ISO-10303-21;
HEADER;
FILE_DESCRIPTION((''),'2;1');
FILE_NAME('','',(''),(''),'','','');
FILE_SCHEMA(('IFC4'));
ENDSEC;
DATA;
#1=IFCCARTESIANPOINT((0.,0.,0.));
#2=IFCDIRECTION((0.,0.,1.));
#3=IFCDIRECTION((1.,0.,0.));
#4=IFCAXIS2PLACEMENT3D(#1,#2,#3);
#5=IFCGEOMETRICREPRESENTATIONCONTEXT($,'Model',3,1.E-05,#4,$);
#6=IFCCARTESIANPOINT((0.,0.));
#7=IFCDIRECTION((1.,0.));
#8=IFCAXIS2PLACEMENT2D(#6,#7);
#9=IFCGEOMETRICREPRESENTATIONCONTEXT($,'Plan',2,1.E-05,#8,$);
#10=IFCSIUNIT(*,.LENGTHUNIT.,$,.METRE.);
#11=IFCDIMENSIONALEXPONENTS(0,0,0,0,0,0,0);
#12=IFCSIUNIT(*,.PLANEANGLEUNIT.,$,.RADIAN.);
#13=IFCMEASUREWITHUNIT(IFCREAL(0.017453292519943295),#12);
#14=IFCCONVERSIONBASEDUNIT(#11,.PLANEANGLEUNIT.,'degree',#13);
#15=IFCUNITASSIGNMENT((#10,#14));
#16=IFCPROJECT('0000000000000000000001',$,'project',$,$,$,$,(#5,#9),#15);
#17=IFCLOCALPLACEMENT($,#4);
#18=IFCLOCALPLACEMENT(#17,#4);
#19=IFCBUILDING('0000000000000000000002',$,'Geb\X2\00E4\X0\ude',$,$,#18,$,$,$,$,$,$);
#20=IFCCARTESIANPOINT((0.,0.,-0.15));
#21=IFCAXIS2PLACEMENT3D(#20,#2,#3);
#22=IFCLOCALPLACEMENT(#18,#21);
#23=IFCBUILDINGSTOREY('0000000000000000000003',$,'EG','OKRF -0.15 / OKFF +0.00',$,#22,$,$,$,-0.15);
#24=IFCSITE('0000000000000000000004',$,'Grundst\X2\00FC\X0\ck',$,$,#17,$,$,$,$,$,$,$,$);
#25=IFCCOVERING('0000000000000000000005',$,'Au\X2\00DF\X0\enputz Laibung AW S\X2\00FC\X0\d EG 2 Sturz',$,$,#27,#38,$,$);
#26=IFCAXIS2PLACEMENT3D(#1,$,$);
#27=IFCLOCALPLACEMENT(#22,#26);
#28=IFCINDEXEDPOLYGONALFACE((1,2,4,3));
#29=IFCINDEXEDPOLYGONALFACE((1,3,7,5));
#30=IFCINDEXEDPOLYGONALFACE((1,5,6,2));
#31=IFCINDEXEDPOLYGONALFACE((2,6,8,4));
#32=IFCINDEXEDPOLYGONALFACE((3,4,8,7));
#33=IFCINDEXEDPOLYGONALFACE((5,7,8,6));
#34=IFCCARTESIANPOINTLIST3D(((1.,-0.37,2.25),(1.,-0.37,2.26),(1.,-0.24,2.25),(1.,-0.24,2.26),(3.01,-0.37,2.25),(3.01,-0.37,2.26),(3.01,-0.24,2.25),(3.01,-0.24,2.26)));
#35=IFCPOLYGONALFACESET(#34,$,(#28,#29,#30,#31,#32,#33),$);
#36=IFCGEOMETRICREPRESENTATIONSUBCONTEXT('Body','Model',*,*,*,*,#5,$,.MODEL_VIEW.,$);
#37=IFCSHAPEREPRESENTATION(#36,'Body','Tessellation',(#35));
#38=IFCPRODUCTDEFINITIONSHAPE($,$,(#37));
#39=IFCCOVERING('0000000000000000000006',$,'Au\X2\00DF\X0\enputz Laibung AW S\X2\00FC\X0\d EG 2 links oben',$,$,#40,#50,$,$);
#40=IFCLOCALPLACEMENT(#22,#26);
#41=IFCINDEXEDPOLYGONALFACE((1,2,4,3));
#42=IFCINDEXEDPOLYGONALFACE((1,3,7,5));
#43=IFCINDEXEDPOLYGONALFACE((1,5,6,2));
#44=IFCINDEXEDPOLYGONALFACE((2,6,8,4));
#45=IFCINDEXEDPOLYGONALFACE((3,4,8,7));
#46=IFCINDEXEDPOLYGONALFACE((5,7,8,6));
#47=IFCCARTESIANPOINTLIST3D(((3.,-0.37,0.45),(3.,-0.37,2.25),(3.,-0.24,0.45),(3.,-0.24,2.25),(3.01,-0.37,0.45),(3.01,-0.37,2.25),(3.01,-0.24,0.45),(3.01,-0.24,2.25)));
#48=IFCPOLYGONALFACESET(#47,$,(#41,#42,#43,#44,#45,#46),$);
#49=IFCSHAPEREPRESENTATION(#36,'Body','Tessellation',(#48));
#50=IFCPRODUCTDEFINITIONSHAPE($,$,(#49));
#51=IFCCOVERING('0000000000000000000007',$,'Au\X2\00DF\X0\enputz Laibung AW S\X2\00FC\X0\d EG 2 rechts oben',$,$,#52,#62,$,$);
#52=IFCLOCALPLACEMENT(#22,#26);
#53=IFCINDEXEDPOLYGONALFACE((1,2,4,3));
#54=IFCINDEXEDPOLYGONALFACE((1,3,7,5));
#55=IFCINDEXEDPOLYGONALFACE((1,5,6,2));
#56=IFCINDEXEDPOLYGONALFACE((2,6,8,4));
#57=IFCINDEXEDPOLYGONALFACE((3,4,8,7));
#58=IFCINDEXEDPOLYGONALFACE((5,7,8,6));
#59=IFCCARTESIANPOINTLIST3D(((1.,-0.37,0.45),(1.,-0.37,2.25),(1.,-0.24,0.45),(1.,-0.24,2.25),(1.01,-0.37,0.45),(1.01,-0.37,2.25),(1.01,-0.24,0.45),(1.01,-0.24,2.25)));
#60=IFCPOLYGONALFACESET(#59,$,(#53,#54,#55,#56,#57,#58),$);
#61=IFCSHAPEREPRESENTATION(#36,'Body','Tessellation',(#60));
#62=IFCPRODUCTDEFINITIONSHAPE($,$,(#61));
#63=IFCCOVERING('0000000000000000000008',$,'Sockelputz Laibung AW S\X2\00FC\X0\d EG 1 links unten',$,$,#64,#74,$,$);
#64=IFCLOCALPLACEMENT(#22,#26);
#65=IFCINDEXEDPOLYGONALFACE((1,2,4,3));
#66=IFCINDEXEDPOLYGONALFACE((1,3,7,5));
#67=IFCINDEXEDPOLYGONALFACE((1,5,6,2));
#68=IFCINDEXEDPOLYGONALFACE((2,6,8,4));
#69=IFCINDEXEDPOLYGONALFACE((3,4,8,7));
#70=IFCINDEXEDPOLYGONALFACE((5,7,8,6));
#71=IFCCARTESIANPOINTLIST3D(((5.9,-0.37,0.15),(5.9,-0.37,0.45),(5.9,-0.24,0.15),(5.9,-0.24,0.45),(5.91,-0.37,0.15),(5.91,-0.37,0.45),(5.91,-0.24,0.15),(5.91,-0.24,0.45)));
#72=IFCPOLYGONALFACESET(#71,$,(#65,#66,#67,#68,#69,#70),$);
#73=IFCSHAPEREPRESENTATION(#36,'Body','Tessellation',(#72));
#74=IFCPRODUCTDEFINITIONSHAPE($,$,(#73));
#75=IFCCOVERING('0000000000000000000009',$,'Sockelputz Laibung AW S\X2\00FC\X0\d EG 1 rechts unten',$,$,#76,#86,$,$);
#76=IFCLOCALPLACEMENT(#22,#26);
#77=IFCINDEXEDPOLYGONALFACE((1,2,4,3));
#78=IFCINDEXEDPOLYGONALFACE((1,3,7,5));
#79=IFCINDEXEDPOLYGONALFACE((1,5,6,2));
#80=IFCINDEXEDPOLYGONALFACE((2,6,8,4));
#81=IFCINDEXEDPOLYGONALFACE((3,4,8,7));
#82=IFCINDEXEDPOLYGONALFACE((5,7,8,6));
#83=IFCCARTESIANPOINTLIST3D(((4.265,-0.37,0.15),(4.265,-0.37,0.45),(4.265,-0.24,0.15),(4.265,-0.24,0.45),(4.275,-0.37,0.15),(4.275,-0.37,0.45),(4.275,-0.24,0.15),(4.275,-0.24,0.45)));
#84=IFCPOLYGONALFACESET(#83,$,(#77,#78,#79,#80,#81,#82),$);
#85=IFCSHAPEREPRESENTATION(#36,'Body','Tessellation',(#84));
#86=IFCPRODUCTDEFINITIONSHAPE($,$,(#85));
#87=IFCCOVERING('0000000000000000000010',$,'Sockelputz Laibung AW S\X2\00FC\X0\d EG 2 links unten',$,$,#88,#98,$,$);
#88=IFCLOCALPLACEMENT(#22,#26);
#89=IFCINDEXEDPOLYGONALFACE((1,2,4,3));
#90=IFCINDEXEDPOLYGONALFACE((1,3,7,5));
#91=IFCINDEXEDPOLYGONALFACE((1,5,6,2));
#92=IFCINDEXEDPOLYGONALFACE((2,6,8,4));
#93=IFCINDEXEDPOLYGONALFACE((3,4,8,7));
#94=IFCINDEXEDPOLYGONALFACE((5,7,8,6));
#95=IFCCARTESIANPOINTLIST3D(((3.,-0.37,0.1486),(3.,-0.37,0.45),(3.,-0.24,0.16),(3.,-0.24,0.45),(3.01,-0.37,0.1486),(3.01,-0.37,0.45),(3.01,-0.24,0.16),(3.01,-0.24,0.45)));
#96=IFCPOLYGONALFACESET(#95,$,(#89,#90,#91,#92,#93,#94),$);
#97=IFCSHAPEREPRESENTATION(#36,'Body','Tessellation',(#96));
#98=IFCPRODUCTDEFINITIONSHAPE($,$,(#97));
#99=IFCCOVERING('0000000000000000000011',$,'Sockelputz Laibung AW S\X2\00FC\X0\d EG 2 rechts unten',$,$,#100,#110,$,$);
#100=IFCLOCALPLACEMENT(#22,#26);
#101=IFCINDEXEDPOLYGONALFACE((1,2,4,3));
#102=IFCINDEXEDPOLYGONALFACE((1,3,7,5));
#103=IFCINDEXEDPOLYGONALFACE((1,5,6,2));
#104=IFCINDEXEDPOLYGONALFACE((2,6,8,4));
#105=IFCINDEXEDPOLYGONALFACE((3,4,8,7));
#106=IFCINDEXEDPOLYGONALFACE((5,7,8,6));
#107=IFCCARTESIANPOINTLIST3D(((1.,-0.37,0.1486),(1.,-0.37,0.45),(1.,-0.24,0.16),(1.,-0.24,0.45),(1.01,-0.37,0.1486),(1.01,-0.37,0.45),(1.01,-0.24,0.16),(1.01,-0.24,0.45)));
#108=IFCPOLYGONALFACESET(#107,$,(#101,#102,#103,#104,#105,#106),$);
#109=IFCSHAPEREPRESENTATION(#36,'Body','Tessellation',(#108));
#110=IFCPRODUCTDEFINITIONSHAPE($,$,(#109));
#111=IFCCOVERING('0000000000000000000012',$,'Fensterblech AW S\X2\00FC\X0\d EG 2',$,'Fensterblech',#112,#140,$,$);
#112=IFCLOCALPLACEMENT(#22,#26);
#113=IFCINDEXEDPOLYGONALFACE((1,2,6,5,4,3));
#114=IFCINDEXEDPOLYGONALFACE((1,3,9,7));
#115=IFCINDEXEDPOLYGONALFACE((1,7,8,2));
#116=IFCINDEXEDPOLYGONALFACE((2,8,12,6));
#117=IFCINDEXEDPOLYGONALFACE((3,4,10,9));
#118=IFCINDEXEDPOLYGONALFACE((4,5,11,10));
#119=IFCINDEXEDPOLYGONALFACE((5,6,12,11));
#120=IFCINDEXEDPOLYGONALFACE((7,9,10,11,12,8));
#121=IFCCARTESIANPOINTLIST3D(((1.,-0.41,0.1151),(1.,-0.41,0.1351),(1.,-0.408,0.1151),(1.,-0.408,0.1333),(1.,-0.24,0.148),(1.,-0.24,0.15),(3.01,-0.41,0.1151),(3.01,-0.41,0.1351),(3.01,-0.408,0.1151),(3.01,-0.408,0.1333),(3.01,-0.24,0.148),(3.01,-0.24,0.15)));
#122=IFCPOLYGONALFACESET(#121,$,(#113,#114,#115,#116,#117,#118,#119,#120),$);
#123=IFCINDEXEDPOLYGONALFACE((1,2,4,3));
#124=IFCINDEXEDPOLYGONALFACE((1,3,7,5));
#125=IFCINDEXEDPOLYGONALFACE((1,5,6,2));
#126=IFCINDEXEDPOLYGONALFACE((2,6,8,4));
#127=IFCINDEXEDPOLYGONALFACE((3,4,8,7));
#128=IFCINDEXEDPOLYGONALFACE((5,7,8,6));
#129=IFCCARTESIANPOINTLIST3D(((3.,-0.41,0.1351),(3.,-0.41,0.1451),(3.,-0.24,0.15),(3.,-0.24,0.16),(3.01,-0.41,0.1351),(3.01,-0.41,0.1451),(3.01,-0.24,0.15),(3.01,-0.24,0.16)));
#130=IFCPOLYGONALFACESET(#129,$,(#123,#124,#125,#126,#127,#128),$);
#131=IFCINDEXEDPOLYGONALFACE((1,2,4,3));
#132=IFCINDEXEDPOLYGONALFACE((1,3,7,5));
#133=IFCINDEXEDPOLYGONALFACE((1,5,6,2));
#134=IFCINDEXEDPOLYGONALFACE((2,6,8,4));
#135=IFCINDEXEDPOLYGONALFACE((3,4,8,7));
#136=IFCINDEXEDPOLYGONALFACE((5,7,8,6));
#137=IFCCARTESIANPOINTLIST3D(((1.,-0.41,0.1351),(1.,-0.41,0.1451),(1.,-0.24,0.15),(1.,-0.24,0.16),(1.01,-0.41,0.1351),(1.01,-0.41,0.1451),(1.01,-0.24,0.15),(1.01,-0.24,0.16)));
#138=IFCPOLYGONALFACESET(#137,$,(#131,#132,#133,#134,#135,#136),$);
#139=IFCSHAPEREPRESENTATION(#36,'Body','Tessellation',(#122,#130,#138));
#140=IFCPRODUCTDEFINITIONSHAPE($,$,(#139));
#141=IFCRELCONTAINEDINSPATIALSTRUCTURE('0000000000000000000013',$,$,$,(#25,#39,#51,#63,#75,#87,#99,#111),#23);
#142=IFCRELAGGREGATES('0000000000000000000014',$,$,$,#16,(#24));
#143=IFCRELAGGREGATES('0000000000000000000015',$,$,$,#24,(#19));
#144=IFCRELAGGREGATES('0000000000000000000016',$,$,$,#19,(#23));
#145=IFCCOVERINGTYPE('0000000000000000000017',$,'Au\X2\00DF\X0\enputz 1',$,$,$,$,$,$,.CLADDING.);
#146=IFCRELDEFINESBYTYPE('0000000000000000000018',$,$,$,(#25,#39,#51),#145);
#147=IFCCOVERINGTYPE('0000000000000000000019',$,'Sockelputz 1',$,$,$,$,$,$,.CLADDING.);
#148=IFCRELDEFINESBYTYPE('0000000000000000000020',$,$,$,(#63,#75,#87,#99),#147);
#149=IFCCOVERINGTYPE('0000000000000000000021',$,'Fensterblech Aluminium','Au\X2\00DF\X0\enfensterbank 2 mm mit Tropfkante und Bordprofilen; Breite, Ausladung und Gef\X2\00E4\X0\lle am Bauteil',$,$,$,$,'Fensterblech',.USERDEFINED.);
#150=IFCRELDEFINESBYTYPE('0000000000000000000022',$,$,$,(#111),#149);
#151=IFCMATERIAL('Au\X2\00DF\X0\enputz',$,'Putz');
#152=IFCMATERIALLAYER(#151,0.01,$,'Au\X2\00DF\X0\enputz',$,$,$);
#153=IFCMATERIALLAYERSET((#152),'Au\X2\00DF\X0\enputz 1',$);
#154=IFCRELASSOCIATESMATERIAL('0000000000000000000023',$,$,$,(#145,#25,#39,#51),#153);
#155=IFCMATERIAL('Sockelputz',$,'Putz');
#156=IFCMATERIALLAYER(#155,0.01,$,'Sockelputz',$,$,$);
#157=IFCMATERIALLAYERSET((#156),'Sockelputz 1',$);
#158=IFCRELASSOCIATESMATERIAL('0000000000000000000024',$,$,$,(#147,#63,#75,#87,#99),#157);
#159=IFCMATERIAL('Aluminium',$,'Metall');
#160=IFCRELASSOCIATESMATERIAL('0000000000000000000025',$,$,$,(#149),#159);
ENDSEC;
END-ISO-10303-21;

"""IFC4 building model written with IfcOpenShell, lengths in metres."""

from ifc_helpers import new_model, entity, si_unit, converted_unit, frame, origin_with_axes, origin_2d_with_axis, place, context, subcontext, project, spatial, polyline, outline, extrude, material, layer, layer_set, layer_usage, type_object, element, save


model = new_model("IFC4")

# Units and contexts
model_context = context("Model", 3, precision=1e-05, world=origin_with_axes())
plan_context = context("Plan", 2, precision=1e-05, world=origin_2d_with_axis())
body_context_1 = subcontext(model_context, "Body", "Model", "MODEL_VIEW")
ifc_project = project(units=[si_unit("LENGTHUNIT", "METRE"), converted_unit("PLANEANGLEUNIT", "degree", entity("IfcReal", 0.017453292519943295), si_unit("PLANEANGLEUNIT", "RADIAN"), dimensions=[0, 0, 0, 0, 0, 0, 0])], contexts=[model_context, plan_context])

# Site, building, storey
site_placement = place(None, origin_with_axes())
site = spatial("IfcSite", under=ifc_project, at=site_placement, Name="Grundstück")
building_placement = place(site_placement, origin_with_axes())
building = spatial("IfcBuilding", under=site, at=building_placement, Name="Gebäude")
storey_placement = place(building_placement, frame((0.0, 0.0, -0.15), z_axis=(0.0, 0.0, 1.0), x_axis=(1.0, 0.0, 0.0)))
storey = spatial("IfcBuildingStorey", under=building, at=storey_placement, Name="EG", Description="OKRF -0.15 / OKFF +0.00", Elevation=-0.15)

# Coverings
ifc_material_1 = material(Name="Außenputz", Category="Putz")
ifc_layer_1 = layer(ifc_material_1, 0.01, Name="Außenputz")
ifc_layer_set_1 = layer_set([ifc_layer_1], Name="Außenputz 1")
covering_type_1 = type_object("IfcCoveringType", Name="Außenputz 1", PredefinedType="CLADDING", material=ifc_layer_set_1)
ifc_layer_usage_1 = layer_usage(ifc_layer_set_1, "AXIS3", "POSITIVE", 2.25)
covering_1_placement = place(storey_placement, frame((9.0, 0.0, 0.0), z_axis=(0.0, 0.0, 1.0), x_axis=(-1.0, 0.0, 0.0)))
element("IfcCovering", 1, at=covering_1_placement, inside=storey, type_object=covering_type_1, material=ifc_layer_usage_1, Name="Außenputz Laibung AW Süd EG 2 Sturz", context=body_context_1, shape_type="SweptSolid", body=[
    extrude(outline(polyline([(0.24, 2.25), (0.37, 2.25), (0.37, 2.26), (0.24, 2.26), (0.24, 2.25)])), frame((5.99, 0.0, 0.0), z_axis=(1.0, 0.0, 0.0), x_axis=(0.0, 1.0, 0.0)), (0.0, 0.0, 1.0), 2.01),
])
ifc_layer_usage_2 = layer_usage(ifc_layer_set_1, "AXIS1", "POSITIVE", 5.99)
covering_2_placement = place(storey_placement, frame((9.0, 0.0, 0.0), z_axis=(0.0, 0.0, 1.0), x_axis=(-1.0, 0.0, 0.0)))
element("IfcCovering", 2, at=covering_2_placement, inside=storey, type_object=covering_type_1, material=ifc_layer_usage_2, Name="Außenputz Laibung AW Süd EG 2 links oben", context=body_context_1, shape_type="SweptSolid", body=[
    extrude(outline(polyline([(0.24, 0.45), (0.37, 0.45), (0.37, 2.25), (0.24, 2.25), (0.24, 0.45)])), frame((5.99, 0.0, 0.0), z_axis=(1.0, 0.0, 0.0), x_axis=(0.0, 1.0, 0.0)), (0.0, 0.0, 1.0), 0.01),
])
ifc_layer_usage_3 = layer_usage(ifc_layer_set_1, "AXIS1", "POSITIVE", 7.99)
covering_3_placement = place(storey_placement, frame((9.0, 0.0, 0.0), z_axis=(0.0, 0.0, 1.0), x_axis=(-1.0, 0.0, 0.0)))
element("IfcCovering", 3, at=covering_3_placement, inside=storey, type_object=covering_type_1, material=ifc_layer_usage_3, Name="Außenputz Laibung AW Süd EG 2 rechts oben", context=body_context_1, shape_type="SweptSolid", body=[
    extrude(outline(polyline([(0.24, 0.45), (0.37, 0.45), (0.37, 2.25), (0.24, 2.25), (0.24, 0.45)])), frame((7.99, 0.0, 0.0), z_axis=(1.0, 0.0, 0.0), x_axis=(0.0, 1.0, 0.0)), (0.0, 0.0, 1.0), 0.01),
])
ifc_material_2 = material(Name="Sockelputz", Category="Putz")
ifc_layer_2 = layer(ifc_material_2, 0.01, Name="Sockelputz")
ifc_layer_set_2 = layer_set([ifc_layer_2], Name="Sockelputz 1")
ifc_layer_usage_4 = layer_usage(ifc_layer_set_2, "AXIS1", "POSITIVE", 3.09)
covering_type_2 = type_object("IfcCoveringType", Name="Sockelputz 1", PredefinedType="CLADDING", material=ifc_layer_set_2)
covering_4_placement = place(storey_placement, frame((9.0, 0.0, 0.0), z_axis=(0.0, 0.0, 1.0), x_axis=(-1.0, 0.0, 0.0)))
element("IfcCovering", 4, at=covering_4_placement, inside=storey, type_object=covering_type_2, material=ifc_layer_usage_4, Name="Sockelputz Laibung AW Süd EG 1 links unten", context=body_context_1, shape_type="SweptSolid", body=[
    extrude(outline(polyline([(0.24, 0.15), (0.37, 0.15), (0.37, 0.45), (0.24, 0.45), (0.24, 0.15)])), frame((3.09, 0.0, 0.0), z_axis=(1.0, 0.0, 0.0), x_axis=(0.0, 1.0, 0.0)), (0.0, 0.0, 1.0), 0.01),
])
ifc_layer_usage_5 = layer_usage(ifc_layer_set_2, "AXIS1", "POSITIVE", 4.725)
covering_5_placement = place(storey_placement, frame((9.0, 0.0, 0.0), z_axis=(0.0, 0.0, 1.0), x_axis=(-1.0, 0.0, 0.0)))
element("IfcCovering", 5, at=covering_5_placement, inside=storey, type_object=covering_type_2, material=ifc_layer_usage_5, Name="Sockelputz Laibung AW Süd EG 1 rechts unten", context=body_context_1, shape_type="SweptSolid", body=[
    extrude(outline(polyline([(0.24, 0.15), (0.37, 0.15), (0.37, 0.45), (0.24, 0.45), (0.24, 0.15)])), frame((4.725, 0.0, 0.0), z_axis=(1.0, 0.0, 0.0), x_axis=(0.0, 1.0, 0.0)), (0.0, 0.0, 1.0), 0.01),
])
ifc_layer_usage_6 = layer_usage(ifc_layer_set_2, "AXIS1", "POSITIVE", 5.99)
covering_6_placement = place(storey_placement, frame((9.0, 0.0, 0.0), z_axis=(0.0, 0.0, 1.0), x_axis=(-1.0, 0.0, 0.0)))
element("IfcCovering", 6, at=covering_6_placement, inside=storey, type_object=covering_type_2, material=ifc_layer_usage_6, Name="Sockelputz Laibung AW Süd EG 2 links unten", context=body_context_1, shape_type="SweptSolid", body=[
    extrude(outline(polyline([(0.24, 0.16), (0.37, 0.1486), (0.37, 0.45), (0.24, 0.45), (0.24, 0.16)])), frame((5.99, 0.0, 0.0), z_axis=(1.0, 0.0, 0.0), x_axis=(0.0, 1.0, 0.0)), (0.0, 0.0, 1.0), 0.01),
])
ifc_layer_usage_7 = layer_usage(ifc_layer_set_2, "AXIS1", "POSITIVE", 7.99)
covering_7_placement = place(storey_placement, frame((9.0, 0.0, 0.0), z_axis=(0.0, 0.0, 1.0), x_axis=(-1.0, 0.0, 0.0)))
element("IfcCovering", 7, at=covering_7_placement, inside=storey, type_object=covering_type_2, material=ifc_layer_usage_7, Name="Sockelputz Laibung AW Süd EG 2 rechts unten", context=body_context_1, shape_type="SweptSolid", body=[
    extrude(outline(polyline([(0.24, 0.16), (0.37, 0.1486), (0.37, 0.45), (0.24, 0.45), (0.24, 0.16)])), frame((7.99, 0.0, 0.0), z_axis=(1.0, 0.0, 0.0), x_axis=(0.0, 1.0, 0.0)), (0.0, 0.0, 1.0), 0.01),
])
ifc_material_3 = material(Name="Aluminium", Category="Metall")
covering_type_3 = type_object("IfcCoveringType", Name="Fensterblech Aluminium", Description="Außenfensterbank 2 mm mit Tropfkante und Bordprofilen; Breite, Ausladung und Gefälle am Bauteil", ElementType="Fensterblech", PredefinedType="USERDEFINED", material=ifc_material_3)
covering_8_placement = place(storey_placement, frame((9.0, 0.0, 0.0), z_axis=(0.0, 0.0, 1.0), x_axis=(-1.0, 0.0, 0.0)))
element("IfcCovering", 8, at=covering_8_placement, inside=storey, type_object=covering_type_3, Name="Fensterblech AW Süd EG 2", ObjectType="Fensterblech", context=body_context_1, shape_type="SweptSolid", body=[
    extrude(outline(polyline([(0.24, 0.148), (0.408, 0.1333), (0.408, 0.1151), (0.41, 0.1151), (0.41, 0.1351), (0.24, 0.15), (0.24, 0.148)])), frame((5.99, 0.0, 0.0), z_axis=(1.0, 0.0, 0.0), x_axis=(0.0, 1.0, 0.0)), (0.0, 0.0, 1.0), 2.01),
    extrude(outline(polyline([(0.24, 0.15), (0.41, 0.1351), (0.41, 0.1451), (0.24, 0.16), (0.24, 0.15)])), frame((5.99, 0.0, 0.0), z_axis=(1.0, 0.0, 0.0), x_axis=(0.0, 1.0, 0.0)), (0.0, 0.0, 1.0), 0.01),
    extrude(outline(polyline([(0.24, 0.15), (0.41, 0.1351), (0.41, 0.1451), (0.24, 0.16), (0.24, 0.15)])), frame((7.99, 0.0, 0.0), z_axis=(1.0, 0.0, 0.0), x_axis=(0.0, 1.0, 0.0)), (0.0, 0.0, 1.0), 0.01),
])

save(model, "model.ifc")
